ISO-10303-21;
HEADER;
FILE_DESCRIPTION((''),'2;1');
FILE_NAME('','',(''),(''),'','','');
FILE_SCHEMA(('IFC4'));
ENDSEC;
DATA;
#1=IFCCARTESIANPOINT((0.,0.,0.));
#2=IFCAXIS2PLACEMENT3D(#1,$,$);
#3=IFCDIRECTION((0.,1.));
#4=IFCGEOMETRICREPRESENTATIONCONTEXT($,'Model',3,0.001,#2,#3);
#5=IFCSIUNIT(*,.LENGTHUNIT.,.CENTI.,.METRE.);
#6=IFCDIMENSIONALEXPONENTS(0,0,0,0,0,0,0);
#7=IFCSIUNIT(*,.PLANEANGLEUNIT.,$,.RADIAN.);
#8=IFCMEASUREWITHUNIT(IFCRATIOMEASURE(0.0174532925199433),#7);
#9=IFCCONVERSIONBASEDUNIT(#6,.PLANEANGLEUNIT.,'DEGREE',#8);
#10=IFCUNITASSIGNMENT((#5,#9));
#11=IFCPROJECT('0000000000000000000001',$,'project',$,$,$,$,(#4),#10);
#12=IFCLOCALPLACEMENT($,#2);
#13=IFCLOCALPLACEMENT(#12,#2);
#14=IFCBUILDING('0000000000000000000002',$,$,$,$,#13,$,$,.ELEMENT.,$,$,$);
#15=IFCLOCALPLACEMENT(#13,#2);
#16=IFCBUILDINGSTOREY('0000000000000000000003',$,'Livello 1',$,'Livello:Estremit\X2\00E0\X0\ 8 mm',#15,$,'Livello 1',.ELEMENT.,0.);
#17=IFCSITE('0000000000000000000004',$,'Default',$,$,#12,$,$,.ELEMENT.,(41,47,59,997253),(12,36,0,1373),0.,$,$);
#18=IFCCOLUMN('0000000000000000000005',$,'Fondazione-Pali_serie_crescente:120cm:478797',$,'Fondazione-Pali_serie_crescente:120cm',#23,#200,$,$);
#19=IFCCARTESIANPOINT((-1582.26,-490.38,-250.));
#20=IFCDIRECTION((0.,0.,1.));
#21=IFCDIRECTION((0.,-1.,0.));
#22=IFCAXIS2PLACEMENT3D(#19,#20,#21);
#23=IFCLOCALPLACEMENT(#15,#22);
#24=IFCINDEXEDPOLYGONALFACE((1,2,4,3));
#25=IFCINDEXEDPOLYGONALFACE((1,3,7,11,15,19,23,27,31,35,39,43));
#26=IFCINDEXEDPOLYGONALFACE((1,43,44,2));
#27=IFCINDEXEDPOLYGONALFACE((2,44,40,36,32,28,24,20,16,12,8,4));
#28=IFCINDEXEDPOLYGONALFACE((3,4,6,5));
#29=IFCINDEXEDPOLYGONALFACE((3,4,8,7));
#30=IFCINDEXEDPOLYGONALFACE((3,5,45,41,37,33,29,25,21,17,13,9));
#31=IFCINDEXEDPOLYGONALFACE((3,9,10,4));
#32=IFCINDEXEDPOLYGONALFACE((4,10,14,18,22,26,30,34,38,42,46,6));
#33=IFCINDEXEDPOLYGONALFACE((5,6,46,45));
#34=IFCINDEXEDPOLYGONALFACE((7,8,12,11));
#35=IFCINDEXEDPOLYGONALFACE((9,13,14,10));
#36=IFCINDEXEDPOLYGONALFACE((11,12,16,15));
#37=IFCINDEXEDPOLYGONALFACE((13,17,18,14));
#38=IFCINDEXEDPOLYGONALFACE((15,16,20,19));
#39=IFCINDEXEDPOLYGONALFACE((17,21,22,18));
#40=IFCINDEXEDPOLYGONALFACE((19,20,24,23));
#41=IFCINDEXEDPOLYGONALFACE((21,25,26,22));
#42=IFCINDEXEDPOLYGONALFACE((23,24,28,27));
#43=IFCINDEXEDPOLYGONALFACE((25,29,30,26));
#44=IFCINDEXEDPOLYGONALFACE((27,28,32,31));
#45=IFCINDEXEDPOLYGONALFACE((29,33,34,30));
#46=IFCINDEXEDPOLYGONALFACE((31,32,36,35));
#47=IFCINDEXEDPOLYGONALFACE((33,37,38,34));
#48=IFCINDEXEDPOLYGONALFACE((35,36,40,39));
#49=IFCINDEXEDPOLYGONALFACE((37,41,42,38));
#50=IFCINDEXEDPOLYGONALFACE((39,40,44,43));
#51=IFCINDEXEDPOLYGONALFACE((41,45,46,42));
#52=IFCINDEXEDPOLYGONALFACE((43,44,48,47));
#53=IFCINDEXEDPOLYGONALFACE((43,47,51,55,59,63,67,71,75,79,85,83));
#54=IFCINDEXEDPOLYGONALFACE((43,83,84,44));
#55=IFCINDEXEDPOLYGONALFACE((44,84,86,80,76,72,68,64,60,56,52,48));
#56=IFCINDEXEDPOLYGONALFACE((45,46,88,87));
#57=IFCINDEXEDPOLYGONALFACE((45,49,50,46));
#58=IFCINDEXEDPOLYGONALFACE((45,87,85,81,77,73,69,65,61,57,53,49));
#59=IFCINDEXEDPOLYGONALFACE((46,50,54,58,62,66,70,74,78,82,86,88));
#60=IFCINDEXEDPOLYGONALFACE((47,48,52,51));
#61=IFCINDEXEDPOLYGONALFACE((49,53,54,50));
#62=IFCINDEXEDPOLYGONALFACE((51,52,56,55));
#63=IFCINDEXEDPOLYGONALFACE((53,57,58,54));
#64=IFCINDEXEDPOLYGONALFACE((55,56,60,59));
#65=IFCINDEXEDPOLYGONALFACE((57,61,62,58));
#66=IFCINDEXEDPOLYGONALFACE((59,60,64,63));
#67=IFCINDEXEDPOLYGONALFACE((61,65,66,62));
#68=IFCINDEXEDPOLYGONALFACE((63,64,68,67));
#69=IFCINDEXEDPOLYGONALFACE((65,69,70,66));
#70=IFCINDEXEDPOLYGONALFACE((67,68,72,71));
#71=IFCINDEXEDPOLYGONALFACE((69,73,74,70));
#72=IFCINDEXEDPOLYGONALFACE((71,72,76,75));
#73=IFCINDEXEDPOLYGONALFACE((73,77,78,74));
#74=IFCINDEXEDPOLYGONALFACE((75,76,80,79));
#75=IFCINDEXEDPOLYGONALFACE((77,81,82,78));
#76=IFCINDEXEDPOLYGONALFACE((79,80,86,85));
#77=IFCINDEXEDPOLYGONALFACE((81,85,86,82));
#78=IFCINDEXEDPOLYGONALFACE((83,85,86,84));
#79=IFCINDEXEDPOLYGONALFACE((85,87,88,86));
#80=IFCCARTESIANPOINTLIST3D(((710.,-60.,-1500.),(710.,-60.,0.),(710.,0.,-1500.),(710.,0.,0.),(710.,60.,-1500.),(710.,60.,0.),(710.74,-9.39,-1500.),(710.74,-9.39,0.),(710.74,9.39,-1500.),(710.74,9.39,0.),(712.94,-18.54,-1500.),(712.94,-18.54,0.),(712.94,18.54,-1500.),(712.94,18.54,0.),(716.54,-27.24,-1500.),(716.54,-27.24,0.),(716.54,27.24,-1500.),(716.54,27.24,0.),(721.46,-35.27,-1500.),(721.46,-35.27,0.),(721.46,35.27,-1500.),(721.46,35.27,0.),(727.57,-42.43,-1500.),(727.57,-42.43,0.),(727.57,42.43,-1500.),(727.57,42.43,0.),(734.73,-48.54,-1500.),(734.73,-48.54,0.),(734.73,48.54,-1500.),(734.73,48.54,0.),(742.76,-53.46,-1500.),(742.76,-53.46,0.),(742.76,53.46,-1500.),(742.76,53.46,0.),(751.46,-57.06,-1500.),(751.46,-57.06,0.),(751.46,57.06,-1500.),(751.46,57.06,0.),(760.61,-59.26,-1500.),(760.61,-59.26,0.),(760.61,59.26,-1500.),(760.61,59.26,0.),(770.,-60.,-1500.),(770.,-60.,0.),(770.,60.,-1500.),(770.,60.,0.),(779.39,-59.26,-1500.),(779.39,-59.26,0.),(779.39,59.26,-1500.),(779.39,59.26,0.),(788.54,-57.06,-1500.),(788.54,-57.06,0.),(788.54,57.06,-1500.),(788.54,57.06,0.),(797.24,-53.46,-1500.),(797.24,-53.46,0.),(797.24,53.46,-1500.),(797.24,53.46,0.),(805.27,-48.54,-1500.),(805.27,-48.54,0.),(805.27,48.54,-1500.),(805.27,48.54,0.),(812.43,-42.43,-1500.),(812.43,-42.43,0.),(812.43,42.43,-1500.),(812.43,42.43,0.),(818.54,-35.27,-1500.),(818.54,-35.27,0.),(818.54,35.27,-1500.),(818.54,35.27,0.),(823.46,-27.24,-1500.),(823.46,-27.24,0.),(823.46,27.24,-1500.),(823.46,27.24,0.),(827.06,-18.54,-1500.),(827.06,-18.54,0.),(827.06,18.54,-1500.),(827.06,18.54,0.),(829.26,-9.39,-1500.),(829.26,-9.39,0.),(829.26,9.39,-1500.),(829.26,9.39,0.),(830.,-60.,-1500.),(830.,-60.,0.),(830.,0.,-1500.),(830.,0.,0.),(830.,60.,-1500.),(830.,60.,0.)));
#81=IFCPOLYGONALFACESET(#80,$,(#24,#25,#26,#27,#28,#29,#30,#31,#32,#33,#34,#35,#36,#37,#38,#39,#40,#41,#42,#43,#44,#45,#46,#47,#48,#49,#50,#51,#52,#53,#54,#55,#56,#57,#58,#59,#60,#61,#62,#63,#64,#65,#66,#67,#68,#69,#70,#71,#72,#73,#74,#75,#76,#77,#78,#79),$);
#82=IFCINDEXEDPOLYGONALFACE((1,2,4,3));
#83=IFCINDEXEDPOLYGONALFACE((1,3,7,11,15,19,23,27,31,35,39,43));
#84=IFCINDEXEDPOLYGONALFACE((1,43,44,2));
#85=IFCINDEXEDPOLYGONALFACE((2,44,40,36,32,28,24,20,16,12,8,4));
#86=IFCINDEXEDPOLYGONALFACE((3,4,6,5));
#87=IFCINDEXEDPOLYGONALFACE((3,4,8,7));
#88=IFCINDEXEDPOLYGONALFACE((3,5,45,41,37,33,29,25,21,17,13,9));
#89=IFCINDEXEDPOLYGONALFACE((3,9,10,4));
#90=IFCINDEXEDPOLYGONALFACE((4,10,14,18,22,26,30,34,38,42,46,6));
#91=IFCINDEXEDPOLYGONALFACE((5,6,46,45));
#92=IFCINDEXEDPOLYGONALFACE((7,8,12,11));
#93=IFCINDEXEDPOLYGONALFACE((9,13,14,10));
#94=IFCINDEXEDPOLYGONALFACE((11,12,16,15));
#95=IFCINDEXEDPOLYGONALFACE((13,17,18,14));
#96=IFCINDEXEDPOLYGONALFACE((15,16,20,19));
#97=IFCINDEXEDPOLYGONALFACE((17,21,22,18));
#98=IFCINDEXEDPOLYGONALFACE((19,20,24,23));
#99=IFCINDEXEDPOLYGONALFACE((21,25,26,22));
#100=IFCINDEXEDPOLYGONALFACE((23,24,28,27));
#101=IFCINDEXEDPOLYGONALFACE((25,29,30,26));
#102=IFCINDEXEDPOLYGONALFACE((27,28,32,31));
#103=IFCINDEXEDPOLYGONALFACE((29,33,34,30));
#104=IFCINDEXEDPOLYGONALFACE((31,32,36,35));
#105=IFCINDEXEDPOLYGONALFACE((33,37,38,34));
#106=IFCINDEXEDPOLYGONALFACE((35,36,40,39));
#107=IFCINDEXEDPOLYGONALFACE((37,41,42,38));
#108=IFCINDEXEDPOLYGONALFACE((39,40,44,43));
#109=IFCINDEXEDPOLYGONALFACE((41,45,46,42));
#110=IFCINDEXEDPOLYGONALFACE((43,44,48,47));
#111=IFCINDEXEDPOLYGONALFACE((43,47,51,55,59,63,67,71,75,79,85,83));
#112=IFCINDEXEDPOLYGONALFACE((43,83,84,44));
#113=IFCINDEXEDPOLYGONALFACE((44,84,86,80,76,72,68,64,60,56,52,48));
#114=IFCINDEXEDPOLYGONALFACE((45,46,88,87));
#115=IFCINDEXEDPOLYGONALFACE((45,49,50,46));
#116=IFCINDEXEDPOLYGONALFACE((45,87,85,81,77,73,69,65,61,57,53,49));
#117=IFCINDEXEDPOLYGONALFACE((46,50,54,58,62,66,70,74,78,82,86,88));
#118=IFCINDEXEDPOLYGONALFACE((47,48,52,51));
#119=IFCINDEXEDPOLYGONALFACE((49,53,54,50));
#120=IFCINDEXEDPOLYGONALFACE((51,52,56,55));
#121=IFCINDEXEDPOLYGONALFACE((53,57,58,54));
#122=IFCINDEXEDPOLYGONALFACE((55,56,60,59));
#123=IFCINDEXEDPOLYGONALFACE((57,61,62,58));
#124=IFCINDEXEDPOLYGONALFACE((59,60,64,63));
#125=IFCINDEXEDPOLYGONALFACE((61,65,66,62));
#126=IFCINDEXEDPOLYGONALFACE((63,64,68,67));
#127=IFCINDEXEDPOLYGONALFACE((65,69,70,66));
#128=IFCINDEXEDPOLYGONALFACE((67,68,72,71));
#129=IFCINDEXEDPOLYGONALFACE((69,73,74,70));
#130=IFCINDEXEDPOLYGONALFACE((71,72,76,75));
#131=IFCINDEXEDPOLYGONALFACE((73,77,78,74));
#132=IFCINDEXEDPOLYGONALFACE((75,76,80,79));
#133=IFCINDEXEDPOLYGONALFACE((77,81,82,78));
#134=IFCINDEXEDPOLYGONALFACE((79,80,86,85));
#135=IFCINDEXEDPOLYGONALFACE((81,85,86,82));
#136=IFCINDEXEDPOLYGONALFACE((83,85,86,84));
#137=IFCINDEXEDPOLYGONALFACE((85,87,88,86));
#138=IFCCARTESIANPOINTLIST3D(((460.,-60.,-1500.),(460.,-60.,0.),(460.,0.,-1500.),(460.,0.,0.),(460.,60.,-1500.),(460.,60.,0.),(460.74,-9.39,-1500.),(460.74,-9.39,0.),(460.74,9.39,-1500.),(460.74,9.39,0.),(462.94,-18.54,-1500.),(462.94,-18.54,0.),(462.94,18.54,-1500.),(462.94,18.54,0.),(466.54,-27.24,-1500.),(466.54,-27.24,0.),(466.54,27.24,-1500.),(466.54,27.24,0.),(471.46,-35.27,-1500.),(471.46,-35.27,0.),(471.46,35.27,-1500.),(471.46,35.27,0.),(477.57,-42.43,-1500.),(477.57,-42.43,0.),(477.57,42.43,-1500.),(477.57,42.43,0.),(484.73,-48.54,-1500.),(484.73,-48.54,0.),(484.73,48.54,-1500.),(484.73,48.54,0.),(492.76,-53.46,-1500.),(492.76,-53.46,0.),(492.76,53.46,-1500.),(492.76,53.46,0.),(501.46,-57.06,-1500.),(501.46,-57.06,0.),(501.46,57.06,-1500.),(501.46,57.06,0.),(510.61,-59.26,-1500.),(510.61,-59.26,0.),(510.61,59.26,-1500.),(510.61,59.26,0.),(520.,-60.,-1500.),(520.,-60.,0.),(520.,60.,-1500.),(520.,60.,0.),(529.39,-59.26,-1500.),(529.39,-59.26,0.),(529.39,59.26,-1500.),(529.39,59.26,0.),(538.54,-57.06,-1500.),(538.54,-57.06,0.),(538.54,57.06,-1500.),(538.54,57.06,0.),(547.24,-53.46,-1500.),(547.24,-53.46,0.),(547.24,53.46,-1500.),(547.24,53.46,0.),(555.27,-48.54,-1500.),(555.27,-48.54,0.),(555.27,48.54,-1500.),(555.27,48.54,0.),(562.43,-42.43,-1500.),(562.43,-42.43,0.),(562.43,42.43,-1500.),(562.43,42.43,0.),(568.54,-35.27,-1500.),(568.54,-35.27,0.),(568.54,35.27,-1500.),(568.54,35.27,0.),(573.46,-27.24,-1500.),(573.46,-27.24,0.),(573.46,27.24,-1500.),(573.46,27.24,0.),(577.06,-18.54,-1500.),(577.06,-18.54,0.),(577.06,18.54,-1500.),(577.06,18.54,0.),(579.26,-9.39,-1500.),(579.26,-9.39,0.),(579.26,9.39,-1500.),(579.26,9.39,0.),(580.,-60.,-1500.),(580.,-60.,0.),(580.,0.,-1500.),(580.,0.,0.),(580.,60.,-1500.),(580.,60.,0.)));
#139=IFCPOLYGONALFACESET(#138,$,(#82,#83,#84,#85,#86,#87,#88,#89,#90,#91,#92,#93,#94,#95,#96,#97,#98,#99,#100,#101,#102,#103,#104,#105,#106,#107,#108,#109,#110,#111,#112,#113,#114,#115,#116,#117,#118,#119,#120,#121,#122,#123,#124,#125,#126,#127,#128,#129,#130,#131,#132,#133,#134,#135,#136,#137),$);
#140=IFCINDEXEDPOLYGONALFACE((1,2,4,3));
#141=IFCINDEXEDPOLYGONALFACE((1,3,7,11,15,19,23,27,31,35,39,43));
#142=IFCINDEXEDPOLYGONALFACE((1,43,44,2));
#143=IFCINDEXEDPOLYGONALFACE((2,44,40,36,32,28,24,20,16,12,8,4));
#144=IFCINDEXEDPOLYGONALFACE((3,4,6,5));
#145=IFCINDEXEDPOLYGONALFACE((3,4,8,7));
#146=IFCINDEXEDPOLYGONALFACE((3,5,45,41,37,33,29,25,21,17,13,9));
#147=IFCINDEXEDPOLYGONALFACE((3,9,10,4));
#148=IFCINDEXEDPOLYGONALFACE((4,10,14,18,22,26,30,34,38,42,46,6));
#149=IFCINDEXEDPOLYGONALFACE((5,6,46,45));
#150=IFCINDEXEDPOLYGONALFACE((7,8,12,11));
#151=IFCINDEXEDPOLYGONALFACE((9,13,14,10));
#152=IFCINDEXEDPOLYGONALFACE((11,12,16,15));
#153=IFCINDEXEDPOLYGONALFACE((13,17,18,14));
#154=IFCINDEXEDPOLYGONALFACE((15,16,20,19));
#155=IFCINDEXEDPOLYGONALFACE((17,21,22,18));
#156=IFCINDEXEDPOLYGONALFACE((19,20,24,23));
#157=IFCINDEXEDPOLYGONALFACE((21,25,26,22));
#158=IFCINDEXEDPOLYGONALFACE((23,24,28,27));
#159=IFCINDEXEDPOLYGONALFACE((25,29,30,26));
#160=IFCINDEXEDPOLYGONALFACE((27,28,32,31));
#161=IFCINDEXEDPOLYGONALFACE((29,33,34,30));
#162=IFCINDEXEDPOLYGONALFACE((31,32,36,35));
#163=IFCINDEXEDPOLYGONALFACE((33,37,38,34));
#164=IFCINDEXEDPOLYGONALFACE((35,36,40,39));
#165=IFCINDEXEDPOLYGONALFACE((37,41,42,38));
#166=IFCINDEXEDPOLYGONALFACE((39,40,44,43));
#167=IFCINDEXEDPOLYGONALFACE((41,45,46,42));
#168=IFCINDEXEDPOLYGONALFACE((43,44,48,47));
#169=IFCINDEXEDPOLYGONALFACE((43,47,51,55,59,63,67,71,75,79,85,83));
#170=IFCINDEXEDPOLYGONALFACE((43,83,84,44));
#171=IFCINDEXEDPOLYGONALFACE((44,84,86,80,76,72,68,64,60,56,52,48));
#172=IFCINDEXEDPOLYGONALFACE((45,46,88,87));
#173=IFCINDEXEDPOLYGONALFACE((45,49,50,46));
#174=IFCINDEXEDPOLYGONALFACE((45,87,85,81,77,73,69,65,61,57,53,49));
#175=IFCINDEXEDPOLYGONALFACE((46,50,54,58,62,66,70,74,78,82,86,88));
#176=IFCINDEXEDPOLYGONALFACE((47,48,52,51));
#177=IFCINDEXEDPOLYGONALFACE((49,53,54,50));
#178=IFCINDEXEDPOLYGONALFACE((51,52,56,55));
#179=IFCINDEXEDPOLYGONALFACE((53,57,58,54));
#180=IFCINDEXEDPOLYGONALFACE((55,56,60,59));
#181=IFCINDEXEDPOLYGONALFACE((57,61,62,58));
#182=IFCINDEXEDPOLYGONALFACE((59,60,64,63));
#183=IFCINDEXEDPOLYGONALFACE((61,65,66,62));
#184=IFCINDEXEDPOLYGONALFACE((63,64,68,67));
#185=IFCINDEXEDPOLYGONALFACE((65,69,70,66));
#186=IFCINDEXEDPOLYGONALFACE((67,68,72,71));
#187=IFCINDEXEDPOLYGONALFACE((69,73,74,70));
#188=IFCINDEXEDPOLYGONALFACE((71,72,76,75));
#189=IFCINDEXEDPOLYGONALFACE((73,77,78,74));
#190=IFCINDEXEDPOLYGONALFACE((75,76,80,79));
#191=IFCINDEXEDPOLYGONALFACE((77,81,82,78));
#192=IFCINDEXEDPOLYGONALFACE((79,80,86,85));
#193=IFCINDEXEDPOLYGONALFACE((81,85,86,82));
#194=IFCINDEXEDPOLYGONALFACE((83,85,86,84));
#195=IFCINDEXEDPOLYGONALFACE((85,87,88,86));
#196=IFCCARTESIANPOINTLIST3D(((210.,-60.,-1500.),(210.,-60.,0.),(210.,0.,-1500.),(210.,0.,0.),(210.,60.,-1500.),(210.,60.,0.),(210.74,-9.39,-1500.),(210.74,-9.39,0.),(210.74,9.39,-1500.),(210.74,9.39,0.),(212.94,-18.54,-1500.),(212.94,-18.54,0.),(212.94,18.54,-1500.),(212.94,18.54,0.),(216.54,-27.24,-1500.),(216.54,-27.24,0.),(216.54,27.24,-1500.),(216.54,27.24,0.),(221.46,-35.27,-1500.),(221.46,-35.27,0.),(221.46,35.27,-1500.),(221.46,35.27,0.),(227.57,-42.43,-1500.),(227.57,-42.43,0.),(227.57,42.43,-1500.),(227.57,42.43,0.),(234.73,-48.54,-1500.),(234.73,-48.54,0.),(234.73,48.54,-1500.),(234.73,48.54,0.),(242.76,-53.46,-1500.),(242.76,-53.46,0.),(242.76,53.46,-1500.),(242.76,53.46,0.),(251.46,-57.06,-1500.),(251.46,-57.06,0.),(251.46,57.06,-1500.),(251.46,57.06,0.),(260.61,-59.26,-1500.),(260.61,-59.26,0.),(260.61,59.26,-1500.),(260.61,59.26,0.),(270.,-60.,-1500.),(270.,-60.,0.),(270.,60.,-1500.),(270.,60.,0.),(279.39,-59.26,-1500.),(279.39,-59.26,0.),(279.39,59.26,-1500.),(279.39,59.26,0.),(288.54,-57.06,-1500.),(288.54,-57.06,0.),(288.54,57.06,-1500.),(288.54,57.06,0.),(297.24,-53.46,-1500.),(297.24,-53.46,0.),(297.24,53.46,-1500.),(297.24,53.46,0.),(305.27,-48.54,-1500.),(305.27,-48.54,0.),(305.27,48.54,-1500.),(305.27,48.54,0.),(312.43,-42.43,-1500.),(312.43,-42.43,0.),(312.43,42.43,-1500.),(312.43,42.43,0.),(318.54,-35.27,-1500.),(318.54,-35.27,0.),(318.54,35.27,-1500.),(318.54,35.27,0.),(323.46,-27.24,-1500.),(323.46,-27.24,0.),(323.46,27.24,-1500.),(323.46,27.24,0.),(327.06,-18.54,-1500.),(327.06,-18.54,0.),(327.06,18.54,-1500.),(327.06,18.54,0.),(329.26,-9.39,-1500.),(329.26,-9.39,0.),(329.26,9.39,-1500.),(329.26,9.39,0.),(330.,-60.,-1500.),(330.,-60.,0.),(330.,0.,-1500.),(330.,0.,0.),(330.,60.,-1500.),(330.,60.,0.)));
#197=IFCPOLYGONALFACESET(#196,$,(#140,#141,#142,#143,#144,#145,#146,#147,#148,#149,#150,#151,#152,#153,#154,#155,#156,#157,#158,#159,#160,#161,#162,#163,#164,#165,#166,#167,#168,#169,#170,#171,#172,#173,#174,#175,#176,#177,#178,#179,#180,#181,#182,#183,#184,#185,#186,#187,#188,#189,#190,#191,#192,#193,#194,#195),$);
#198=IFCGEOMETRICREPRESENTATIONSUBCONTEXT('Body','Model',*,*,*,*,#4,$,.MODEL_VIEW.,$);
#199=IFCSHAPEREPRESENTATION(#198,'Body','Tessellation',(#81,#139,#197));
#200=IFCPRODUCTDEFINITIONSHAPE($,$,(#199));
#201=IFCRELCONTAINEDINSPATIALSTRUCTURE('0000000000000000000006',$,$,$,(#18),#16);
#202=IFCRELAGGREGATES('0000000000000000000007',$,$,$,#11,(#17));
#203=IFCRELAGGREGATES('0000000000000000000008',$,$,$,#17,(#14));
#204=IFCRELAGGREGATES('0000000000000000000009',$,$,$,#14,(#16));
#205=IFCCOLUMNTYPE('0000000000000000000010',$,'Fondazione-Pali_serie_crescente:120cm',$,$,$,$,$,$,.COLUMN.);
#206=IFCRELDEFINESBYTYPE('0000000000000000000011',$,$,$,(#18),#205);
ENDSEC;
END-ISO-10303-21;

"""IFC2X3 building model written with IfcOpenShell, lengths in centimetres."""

from ifc_helpers import new_model, entity, si_unit, converted_unit, direction, frame, frame_2d, origin, origin_2d_with_axis, place, context, subcontext, project, spatial, rectangle, circle, extrude, boolean, source, transform, mapped, type_object, type_shapes, element, save


model = new_model("IFC2X3")

# Units and contexts
model_context = context("Model", 3, precision=0.001, world=origin(), true_north=direction((0.0, 1.0)))
body_context = subcontext(model_context, "Body", "Model", "MODEL_VIEW")
ifc_project = project(units=[si_unit("LENGTHUNIT", "METRE", prefix="CENTI"), converted_unit("PLANEANGLEUNIT", "DEGREE", entity("IfcRatioMeasure", 0.0174532925199433), si_unit("PLANEANGLEUNIT", "RADIAN"), dimensions=[0, 0, 0, 0, 0, 0, 0])], contexts=[model_context])

# Site, building, storey
site_placement = place(None, origin())
site = spatial("IfcSite", under=ifc_project, at=site_placement, Name="Default", CompositionType="ELEMENT", RefLatitude=(41, 47, 59, 997253), RefLongitude=(12, 36, 0, 1373), RefElevation=0.0)
building_placement = place(site_placement, origin())
building = spatial("IfcBuilding", under=site, at=building_placement, CompositionType="ELEMENT")
storey_placement = place(building_placement, origin())
storey = spatial("IfcBuildingStorey", under=building, at=storey_placement, Name="Livello 1", ObjectType="Livello:Estremità 8 mm", LongName="Livello 1", CompositionType="ELEMENT", Elevation=0.0)

# Column
column_type_1 = type_object("IfcColumnType", Name="Fondazione-Pali_serie_crescente:120cm", PredefinedType="COLUMN")
shared_shape_1 = source(origin(), body_context, "Body", "SweptSolid", [
    boolean("DIFFERENCE", extrude(rectangle(XDim=1500.0, YDim=120.0, at=origin_2d_with_axis()), frame((710.0, 0.0, -750.0), z_axis=(1.0, 0.0, 0.0), x_axis=(0.0, 0.0, -1.0)), (0.0, 0.0, 1.0), 120.0), extrude(circle(Radius=60.0, at=frame_2d((0.0, 0.0), x_axis=(1.0, 0.0))), frame((770.0, 0.0, 0.0)), (0.0, 0.0, -1.0), 1500.0)),
    boolean("DIFFERENCE", extrude(rectangle(XDim=1500.0, YDim=120.0, at=origin_2d_with_axis()), frame((460.0, 0.0, -750.0), z_axis=(1.0, 0.0, 0.0), x_axis=(0.0, 0.0, -1.0)), (0.0, 0.0, 1.0), 120.0), extrude(circle(Radius=60.0, at=frame_2d((0.0, 0.0), x_axis=(1.0, 0.0))), frame((520.0, 0.0, 0.0)), (0.0, 0.0, -1.0), 1500.0)),
    boolean("DIFFERENCE", extrude(rectangle(XDim=1500.0, YDim=120.0, at=origin_2d_with_axis()), frame((210.0, 0.0, -750.0), z_axis=(1.0, 0.0, 0.0), x_axis=(0.0, 0.0, -1.0)), (0.0, 0.0, 1.0), 120.0), extrude(circle(Radius=60.0, at=frame_2d((0.0, 0.0), x_axis=(1.0, 0.0))), frame((270.0, 0.0, 0.0)), (0.0, 0.0, -1.0), 1500.0)),
])
type_shapes(column_type_1, [shared_shape_1])
for number, where, z_axis, x_axis, name in (
    (1, (-1582.26, -490.38, -250.0), (0.0, 0.0, 1.0), (0.0, -1.0, 0.0), "Fondazione-Pali_serie_crescente:120cm:478797"),
):
    element("IfcColumn", number, at=place(storey_placement, frame(where, z_axis=z_axis, x_axis=x_axis)), inside=storey, type_object=column_type_1, Name=name, ObjectType="Fondazione-Pali_serie_crescente:120cm", context=body_context, shape_type="MappedRepresentation", body=[
        mapped(shared_shape_1, transform((0.0, 0.0, 0.0), scale=1.0)),
    ])

save(model, "model.ifc")
